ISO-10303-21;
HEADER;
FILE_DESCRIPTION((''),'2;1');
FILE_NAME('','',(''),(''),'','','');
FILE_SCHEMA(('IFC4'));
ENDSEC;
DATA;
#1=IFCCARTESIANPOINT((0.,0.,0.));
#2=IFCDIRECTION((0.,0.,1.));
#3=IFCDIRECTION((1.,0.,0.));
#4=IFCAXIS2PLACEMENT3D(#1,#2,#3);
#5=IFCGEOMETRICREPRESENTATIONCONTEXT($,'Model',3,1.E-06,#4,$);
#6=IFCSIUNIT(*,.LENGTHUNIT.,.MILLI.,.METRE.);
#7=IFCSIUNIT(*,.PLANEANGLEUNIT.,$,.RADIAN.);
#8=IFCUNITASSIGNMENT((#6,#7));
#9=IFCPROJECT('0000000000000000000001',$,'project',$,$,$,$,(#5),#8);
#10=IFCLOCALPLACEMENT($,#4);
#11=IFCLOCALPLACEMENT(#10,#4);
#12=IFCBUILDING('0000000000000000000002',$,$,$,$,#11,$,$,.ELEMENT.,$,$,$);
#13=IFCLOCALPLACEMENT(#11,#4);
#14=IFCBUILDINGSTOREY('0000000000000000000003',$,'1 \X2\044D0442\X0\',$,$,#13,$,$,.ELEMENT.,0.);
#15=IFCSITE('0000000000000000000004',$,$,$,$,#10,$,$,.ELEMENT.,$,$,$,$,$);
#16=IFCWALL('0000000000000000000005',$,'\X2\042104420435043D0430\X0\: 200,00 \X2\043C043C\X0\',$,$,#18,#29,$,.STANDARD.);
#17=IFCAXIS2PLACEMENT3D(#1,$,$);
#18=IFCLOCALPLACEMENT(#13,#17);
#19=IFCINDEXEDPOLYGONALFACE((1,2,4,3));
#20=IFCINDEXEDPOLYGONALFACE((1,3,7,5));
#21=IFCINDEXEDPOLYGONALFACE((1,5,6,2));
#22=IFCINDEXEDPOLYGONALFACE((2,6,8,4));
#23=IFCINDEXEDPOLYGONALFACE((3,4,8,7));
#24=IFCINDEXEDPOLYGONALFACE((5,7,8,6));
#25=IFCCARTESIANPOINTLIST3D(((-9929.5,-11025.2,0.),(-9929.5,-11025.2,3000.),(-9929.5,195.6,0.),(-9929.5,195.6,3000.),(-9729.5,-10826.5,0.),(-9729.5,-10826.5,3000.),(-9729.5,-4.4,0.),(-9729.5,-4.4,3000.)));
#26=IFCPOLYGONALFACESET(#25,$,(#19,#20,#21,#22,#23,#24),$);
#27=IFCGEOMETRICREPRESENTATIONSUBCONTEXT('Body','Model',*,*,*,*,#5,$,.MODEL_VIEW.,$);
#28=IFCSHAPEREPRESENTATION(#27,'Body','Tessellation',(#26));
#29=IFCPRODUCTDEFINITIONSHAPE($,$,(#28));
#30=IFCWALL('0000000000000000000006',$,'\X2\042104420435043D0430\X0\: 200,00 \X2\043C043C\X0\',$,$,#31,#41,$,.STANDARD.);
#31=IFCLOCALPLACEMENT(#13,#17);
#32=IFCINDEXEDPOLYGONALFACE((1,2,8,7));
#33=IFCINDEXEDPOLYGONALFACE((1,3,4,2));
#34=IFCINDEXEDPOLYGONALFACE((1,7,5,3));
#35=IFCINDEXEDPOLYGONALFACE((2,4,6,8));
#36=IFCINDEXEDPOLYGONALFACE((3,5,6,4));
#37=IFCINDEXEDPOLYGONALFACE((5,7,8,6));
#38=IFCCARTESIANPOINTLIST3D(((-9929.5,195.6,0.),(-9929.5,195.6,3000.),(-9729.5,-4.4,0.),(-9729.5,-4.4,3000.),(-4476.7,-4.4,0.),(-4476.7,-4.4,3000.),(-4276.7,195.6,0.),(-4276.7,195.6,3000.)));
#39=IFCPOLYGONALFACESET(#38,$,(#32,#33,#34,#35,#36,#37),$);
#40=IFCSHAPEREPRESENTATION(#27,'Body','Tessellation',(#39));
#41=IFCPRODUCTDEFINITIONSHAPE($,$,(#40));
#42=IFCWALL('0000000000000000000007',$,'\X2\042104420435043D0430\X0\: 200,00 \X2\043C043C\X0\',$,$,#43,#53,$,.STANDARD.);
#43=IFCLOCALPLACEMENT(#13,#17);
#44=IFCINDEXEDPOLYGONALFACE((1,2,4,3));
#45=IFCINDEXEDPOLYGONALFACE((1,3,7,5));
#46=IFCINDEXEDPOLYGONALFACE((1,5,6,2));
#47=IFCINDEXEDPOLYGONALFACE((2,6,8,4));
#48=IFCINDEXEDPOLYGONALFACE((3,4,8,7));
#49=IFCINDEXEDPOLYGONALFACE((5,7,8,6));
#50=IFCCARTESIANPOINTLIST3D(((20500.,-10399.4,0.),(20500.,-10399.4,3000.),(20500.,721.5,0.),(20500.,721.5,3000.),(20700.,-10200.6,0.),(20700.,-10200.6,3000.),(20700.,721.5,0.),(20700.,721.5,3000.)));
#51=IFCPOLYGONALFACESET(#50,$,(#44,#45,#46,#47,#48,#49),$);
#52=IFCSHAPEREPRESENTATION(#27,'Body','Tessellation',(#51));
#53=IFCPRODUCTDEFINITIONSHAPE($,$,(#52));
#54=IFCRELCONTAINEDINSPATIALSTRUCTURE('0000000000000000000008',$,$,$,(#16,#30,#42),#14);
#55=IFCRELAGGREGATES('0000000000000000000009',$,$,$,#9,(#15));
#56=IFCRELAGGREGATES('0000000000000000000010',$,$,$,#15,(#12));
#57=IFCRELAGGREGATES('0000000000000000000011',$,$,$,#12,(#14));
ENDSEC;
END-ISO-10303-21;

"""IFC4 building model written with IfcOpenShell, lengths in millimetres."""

from ifc_helpers import new_model, si_unit, frame, origin_with_axes, place, context, subcontext, project, spatial, line, indexed_curve, outline, extrude, source, transform, mapped, element, save


model = new_model("IFC4")

# Units and contexts
model_context = context("Model", 3, precision=1e-06, world=origin_with_axes())
body_context = subcontext(model_context, "Body", "Model", "MODEL_VIEW")
ifc_project = project(units=[si_unit("LENGTHUNIT", "METRE", prefix="MILLI"), si_unit("PLANEANGLEUNIT", "RADIAN")], contexts=[model_context])

# Site, building, storey
site_placement = place(None, origin_with_axes())
site = spatial("IfcSite", under=ifc_project, at=site_placement, CompositionType="ELEMENT")
building_placement = place(site_placement, origin_with_axes())
building = spatial("IfcBuilding", under=site, at=building_placement, CompositionType="ELEMENT")
storey_placement = place(building_placement, origin_with_axes())
storey = spatial("IfcBuildingStorey", under=building, at=storey_placement, Name="1 эт", CompositionType="ELEMENT", Elevation=0.0)

# Walls
shared_shape_1 = source(origin_with_axes(), body_context, "Body", "SweptSolid", [
    extrude(outline(indexed_curve([(99.4, -100.0), (10921.5, -100.0), (11121.5, 100.0), (-99.4, 100.0)], segments=[line(1, 2), line(2, 3), line(3, 4), line(4, 1)])), origin_with_axes(), (0.0, 0.0, 1.0), 3000.0),
])
wall_1_placement = place(storey_placement, frame((-9829.5, -10925.9, 0.0), z_axis=(0.0, 0.0, 1.0), x_axis=(0.0, 1.0, 0.0)))
element("IfcWall", 1, at=wall_1_placement, inside=storey, Name="Стена: 200,00 мм", PredefinedType="STANDARD", context=body_context, shape_type="MappedRepresentation", body=[
    mapped(shared_shape_1, transform((0.0, 0.0, 0.0), x_axis=(1.0, 0.0, 0.0), y_axis=(0.0, 1.0, 0.0), z_axis=(0.0, 0.0, 1.0), scale=1.0)),
])
shared_shape_2 = source(origin_with_axes(), body_context, "Body", "SweptSolid", [
    extrude(outline(indexed_curve([(100.0, -100.0), (5352.8, -100.0), (5552.8, 100.0), (-100.0, 100.0)], segments=[line(1, 2), line(2, 3), line(3, 4), line(4, 1)])), origin_with_axes(), (0.0, 0.0, 1.0), 3000.0),
])
wall_2_placement = place(storey_placement, frame((-9829.5, 95.6, 0.0), z_axis=(0.0, 0.0, 1.0), x_axis=(1.0, 0.0, 0.0)))
element("IfcWall", 2, at=wall_2_placement, inside=storey, Name="Стена: 200,00 мм", PredefinedType="STANDARD", context=body_context, shape_type="MappedRepresentation", body=[
    mapped(shared_shape_2, transform((0.0, 0.0, 0.0), x_axis=(1.0, 0.0, 0.0), y_axis=(0.0, 1.0, 0.0), z_axis=(0.0, 0.0, 1.0), scale=1.0)),
])
shared_shape_3 = source(origin_with_axes(), body_context, "Body", "SweptSolid", [
    extrude(outline(indexed_curve([(99.4, -100.0), (11021.5, -100.0), (11021.5, 100.0), (-99.4, 100.0)], segments=[line(1, 2), line(2, 3), line(3, 4), line(4, 1)])), origin_with_axes(), (0.0, 0.0, 1.0), 3000.0),
])
wall_3_placement = place(storey_placement, frame((20600.0, -10300.0, 0.0), z_axis=(0.0, 0.0, 1.0), x_axis=(0.0, 1.0, 0.0)))
element("IfcWall", 3, at=wall_3_placement, inside=storey, Name="Стена: 200,00 мм", PredefinedType="STANDARD", context=body_context, shape_type="MappedRepresentation", body=[
    mapped(shared_shape_3, transform((0.0, 0.0, 0.0), x_axis=(1.0, 0.0, 0.0), y_axis=(0.0, 1.0, 0.0), z_axis=(0.0, 0.0, 1.0), scale=1.0)),
])

save(model, "model.ifc")
